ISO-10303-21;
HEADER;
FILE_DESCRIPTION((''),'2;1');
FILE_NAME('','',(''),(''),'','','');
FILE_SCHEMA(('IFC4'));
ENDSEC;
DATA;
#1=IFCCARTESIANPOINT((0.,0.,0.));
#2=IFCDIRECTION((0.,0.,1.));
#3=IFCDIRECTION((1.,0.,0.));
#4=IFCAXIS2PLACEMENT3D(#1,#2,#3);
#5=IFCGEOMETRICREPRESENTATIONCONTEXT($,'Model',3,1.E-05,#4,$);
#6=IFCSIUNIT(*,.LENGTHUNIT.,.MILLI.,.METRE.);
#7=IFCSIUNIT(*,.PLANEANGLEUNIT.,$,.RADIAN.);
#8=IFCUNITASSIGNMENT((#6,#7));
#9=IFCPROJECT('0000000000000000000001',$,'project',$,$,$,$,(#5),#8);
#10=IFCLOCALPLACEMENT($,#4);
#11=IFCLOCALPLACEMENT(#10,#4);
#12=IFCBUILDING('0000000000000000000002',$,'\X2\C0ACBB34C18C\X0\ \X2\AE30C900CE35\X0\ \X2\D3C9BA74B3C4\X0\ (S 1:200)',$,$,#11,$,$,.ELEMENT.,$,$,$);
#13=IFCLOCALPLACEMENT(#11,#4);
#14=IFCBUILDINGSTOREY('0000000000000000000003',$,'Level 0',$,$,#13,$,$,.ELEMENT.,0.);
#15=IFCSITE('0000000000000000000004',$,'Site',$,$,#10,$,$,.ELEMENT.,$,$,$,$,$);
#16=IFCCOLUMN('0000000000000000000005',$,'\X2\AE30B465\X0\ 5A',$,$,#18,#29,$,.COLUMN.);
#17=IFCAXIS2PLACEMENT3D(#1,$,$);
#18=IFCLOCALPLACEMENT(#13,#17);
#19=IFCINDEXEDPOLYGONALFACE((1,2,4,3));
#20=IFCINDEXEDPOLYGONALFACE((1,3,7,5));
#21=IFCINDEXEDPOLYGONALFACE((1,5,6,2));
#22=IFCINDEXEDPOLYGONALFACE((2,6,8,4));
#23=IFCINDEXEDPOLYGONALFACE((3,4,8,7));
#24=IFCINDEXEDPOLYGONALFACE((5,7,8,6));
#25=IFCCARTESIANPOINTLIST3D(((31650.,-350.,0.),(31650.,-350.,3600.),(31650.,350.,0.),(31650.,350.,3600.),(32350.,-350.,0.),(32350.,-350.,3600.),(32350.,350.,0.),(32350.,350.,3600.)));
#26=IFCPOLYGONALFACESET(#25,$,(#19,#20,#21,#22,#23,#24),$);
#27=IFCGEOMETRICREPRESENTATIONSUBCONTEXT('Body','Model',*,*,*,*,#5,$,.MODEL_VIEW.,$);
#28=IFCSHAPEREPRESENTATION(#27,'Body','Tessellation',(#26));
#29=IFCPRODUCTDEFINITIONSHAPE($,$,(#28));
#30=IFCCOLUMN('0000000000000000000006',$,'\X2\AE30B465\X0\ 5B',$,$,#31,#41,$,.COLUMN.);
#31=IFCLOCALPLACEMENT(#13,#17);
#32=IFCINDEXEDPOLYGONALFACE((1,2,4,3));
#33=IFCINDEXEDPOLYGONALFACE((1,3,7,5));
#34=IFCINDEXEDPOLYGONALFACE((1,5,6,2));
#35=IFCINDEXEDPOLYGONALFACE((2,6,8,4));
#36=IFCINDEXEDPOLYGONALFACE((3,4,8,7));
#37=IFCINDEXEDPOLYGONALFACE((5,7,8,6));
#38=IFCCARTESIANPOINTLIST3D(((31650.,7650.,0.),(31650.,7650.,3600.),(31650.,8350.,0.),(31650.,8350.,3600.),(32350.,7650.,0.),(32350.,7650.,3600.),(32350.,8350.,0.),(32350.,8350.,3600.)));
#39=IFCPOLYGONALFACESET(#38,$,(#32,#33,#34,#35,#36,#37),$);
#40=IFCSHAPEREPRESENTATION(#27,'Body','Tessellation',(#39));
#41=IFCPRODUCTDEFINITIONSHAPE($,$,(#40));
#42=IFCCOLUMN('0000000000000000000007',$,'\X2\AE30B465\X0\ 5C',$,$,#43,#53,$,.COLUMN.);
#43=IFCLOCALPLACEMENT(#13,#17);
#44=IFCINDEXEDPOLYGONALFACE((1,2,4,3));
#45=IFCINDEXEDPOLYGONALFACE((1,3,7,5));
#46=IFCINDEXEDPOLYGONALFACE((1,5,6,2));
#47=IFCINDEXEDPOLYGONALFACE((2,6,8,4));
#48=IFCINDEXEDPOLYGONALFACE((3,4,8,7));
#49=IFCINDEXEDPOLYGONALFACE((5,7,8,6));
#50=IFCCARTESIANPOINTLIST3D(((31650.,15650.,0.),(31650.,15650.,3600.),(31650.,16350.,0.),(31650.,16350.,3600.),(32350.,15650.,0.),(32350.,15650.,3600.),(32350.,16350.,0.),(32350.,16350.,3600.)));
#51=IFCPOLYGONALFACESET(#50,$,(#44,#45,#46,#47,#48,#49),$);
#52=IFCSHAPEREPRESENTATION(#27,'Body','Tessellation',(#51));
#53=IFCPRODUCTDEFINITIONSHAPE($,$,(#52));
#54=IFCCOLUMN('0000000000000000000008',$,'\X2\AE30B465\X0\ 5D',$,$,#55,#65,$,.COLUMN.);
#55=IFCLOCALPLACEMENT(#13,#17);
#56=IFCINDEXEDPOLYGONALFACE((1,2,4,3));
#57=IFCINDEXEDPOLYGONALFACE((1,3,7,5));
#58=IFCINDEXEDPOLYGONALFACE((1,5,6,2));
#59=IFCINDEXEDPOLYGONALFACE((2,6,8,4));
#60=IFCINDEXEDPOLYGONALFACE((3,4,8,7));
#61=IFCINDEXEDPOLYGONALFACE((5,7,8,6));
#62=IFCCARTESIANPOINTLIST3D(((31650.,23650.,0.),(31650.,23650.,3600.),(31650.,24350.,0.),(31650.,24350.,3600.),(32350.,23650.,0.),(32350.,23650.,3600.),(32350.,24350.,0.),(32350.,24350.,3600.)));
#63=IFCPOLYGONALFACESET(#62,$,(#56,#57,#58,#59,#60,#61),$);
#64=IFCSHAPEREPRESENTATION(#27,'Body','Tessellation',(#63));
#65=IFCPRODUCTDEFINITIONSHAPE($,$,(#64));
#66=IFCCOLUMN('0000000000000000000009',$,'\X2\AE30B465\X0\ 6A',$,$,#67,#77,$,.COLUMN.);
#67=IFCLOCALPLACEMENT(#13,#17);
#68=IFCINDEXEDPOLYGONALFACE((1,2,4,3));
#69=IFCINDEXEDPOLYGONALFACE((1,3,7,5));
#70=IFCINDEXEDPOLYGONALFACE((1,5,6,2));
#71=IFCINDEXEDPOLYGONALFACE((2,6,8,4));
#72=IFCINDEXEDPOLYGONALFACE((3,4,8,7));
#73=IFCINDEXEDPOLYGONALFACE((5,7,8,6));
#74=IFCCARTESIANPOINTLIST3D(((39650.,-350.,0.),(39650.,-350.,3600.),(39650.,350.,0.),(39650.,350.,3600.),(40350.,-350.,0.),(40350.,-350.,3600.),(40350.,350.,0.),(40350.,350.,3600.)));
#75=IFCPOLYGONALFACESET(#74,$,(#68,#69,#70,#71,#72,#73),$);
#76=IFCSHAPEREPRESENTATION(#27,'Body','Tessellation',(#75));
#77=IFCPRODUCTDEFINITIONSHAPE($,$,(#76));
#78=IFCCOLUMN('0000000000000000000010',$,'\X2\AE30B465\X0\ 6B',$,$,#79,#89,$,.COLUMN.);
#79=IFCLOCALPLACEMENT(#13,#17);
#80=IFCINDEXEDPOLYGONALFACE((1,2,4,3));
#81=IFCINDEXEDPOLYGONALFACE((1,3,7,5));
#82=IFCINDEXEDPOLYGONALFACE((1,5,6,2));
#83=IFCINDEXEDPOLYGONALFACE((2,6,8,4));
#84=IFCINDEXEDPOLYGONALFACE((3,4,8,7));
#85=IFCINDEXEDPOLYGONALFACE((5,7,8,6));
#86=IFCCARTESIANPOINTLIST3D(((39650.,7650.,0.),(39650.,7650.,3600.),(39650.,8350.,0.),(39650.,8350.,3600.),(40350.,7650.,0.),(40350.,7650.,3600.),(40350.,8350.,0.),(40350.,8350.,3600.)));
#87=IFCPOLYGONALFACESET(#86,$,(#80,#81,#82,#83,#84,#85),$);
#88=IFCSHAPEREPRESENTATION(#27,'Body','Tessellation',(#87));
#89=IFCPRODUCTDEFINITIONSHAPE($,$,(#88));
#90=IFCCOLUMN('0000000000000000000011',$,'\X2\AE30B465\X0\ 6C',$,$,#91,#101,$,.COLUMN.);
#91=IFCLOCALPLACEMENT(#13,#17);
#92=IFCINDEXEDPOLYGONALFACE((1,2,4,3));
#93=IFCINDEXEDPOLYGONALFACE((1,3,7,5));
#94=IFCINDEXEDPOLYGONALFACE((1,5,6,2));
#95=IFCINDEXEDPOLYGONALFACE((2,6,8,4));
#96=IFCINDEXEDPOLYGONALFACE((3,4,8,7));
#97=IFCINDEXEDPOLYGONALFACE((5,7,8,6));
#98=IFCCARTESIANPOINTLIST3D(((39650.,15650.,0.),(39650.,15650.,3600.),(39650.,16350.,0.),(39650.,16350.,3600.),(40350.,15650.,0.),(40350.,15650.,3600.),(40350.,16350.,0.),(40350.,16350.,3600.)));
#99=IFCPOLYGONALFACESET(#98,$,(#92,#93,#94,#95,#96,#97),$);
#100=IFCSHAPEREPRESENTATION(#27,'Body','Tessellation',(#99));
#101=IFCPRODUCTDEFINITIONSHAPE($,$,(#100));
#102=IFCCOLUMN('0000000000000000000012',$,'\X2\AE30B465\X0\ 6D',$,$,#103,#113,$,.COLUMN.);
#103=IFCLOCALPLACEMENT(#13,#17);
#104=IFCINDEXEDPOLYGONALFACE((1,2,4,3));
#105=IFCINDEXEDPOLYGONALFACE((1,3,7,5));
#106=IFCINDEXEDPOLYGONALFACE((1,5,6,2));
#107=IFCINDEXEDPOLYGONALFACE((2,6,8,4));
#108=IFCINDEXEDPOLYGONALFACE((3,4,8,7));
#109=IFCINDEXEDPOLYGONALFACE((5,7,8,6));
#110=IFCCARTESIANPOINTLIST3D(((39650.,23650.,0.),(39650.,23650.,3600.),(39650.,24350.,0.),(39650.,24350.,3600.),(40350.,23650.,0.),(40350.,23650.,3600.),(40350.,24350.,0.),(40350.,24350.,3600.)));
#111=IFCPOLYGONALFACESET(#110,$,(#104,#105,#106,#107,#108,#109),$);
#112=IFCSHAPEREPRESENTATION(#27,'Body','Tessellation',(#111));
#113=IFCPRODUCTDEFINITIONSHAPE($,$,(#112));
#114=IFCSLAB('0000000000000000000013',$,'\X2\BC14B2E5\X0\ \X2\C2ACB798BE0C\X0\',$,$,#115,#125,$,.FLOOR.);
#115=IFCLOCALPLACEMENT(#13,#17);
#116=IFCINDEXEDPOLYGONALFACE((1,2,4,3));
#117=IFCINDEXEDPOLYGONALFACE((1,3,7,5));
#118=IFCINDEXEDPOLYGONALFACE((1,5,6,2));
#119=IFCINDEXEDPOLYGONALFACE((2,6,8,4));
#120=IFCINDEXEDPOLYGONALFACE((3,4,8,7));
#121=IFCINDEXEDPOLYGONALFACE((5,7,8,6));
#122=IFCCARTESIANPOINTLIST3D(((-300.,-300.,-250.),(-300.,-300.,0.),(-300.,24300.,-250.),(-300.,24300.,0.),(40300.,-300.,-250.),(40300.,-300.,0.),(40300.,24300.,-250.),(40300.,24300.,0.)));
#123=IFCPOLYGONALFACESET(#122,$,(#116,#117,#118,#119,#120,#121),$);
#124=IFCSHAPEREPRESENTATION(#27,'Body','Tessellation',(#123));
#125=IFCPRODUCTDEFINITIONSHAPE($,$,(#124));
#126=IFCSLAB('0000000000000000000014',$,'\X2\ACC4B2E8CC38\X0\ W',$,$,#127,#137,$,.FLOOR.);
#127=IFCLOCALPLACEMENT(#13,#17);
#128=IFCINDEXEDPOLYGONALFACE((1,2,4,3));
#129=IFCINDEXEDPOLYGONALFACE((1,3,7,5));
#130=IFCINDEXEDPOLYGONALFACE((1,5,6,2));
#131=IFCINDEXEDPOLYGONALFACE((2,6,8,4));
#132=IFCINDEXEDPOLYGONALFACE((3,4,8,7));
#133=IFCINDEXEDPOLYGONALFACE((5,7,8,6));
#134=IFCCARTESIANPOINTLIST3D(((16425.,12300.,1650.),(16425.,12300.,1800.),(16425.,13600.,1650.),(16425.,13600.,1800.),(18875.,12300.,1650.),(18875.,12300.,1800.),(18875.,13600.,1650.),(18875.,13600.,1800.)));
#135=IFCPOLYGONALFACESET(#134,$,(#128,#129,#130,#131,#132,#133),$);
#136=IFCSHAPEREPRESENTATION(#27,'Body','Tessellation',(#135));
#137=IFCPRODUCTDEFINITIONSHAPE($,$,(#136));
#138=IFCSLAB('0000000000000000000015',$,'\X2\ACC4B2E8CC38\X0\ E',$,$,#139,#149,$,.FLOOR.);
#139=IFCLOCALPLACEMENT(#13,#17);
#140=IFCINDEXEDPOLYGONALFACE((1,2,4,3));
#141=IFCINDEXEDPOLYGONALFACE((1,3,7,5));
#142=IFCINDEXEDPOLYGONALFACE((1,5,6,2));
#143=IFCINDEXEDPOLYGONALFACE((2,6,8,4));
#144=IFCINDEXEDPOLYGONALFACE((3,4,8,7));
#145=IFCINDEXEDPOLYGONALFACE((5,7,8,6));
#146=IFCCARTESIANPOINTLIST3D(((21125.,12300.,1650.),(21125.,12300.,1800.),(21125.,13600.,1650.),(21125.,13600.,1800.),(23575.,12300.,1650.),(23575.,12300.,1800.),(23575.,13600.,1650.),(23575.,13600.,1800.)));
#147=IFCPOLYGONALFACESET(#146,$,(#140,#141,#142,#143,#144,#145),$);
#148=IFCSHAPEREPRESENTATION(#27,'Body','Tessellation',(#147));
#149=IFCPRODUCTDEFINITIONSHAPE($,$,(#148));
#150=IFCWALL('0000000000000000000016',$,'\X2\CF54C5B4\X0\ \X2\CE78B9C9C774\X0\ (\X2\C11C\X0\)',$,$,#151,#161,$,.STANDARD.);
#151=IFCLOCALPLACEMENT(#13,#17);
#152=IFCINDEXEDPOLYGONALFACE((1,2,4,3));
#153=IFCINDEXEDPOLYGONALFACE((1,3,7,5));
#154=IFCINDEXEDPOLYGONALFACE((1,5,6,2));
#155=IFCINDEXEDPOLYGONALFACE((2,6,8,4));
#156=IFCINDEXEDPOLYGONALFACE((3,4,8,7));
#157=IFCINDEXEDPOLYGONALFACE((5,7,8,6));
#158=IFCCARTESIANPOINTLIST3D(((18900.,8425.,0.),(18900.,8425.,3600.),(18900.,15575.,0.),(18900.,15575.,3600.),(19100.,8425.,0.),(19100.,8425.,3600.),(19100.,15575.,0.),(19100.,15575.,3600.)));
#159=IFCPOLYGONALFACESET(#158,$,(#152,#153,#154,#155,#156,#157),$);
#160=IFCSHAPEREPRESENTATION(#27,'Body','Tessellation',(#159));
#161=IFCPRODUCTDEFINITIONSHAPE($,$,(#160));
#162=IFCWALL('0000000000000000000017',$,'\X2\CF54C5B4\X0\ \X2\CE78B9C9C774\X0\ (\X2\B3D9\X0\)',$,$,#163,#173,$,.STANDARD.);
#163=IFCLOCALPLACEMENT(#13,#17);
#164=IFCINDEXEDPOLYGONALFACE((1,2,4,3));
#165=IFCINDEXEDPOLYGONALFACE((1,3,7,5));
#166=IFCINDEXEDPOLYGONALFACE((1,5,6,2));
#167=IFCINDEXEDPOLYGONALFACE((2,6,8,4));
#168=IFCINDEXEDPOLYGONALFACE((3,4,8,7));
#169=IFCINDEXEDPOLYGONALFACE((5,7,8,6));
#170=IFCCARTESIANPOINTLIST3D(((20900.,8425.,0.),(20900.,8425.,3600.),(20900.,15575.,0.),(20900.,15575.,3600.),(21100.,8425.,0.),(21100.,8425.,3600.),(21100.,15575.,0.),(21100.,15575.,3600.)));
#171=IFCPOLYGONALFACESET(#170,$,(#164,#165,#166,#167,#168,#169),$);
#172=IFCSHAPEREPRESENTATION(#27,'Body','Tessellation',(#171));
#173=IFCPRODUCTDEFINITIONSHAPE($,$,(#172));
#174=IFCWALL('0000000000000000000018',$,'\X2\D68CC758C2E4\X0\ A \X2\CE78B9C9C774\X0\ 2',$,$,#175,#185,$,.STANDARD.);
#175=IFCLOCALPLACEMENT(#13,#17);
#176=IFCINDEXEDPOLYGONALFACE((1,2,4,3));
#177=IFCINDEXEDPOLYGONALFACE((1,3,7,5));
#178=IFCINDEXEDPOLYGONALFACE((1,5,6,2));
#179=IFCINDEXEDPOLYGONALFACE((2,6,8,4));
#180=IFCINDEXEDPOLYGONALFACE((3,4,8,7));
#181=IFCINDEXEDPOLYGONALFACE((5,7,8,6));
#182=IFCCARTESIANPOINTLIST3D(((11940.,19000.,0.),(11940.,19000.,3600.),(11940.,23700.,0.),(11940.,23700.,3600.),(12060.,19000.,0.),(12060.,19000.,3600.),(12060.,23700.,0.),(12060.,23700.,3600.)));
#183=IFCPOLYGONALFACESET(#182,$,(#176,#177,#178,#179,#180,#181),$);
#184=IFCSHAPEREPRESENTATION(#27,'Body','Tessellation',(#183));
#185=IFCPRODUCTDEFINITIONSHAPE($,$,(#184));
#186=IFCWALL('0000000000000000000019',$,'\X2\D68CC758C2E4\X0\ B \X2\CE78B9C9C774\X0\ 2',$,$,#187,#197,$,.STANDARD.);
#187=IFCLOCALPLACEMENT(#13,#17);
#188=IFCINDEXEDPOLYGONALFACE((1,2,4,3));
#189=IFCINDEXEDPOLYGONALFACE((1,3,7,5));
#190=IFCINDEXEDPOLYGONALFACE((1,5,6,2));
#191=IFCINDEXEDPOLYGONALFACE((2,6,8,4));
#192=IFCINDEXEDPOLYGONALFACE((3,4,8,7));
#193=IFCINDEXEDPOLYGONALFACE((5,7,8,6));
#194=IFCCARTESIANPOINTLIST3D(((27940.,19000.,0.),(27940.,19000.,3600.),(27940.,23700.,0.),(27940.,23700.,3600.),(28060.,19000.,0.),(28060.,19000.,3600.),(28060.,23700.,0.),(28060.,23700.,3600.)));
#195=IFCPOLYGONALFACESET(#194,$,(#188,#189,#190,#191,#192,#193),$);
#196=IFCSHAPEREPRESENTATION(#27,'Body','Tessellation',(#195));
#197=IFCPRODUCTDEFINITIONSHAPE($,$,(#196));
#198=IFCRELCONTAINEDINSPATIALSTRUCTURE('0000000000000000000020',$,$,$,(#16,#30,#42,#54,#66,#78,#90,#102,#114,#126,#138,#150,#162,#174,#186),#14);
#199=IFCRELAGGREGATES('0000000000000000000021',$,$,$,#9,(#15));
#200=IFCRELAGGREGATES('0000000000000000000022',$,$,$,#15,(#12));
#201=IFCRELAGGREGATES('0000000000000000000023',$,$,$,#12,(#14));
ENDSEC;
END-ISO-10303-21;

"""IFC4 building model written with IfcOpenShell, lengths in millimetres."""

from ifc_helpers import new_model, si_unit, frame, frame_2d, origin_with_axes, origin_2d, place, context, subcontext, project, spatial, polyline, rectangle, outline, extrude, element, save


model = new_model("IFC4")

# Units and contexts
model_context = context("Model", 3, precision=1e-05, world=origin_with_axes())
body_context = subcontext(model_context, "Body", "Model", "MODEL_VIEW")
ifc_project = project(units=[si_unit("LENGTHUNIT", "METRE", prefix="MILLI"), si_unit("PLANEANGLEUNIT", "RADIAN")], contexts=[model_context])

# Site, building, storey
site_placement = place(None, origin_with_axes())
site = spatial("IfcSite", under=ifc_project, at=site_placement, Name="Site", CompositionType="ELEMENT")
building_placement = place(site_placement, origin_with_axes())
building = spatial("IfcBuilding", under=site, at=building_placement, Name="사무소 기준층 평면도 (S 1:200)", CompositionType="ELEMENT")
storey_placement = place(building_placement, origin_with_axes())
storey = spatial("IfcBuildingStorey", under=building, at=storey_placement, Name="Level 0", CompositionType="ELEMENT", Elevation=0.0)

# Columns
column_1_placement = place(storey_placement, origin_with_axes())
element("IfcColumn", 1, at=column_1_placement, inside=storey, Name="기둥 5A", PredefinedType="COLUMN", context=body_context, shape_type="SweptSolid", body=[
    extrude(rectangle(XDim=700.0, YDim=700.0, at=origin_2d()), frame((32000.0, 0.0, 0.0), z_axis=(0.0, 0.0, 1.0), x_axis=(1.0, 0.0, 0.0)), (0.0, 0.0, 1.0), 3600.0),
])
column_2_placement = place(storey_placement, origin_with_axes())
element("IfcColumn", 2, at=column_2_placement, inside=storey, Name="기둥 5B", PredefinedType="COLUMN", context=body_context, shape_type="SweptSolid", body=[
    extrude(rectangle(XDim=700.0, YDim=700.0, at=origin_2d()), frame((32000.0, 8000.0, 0.0), z_axis=(0.0, 0.0, 1.0), x_axis=(1.0, 0.0, 0.0)), (0.0, 0.0, 1.0), 3600.0),
])
column_3_placement = place(storey_placement, origin_with_axes())
element("IfcColumn", 3, at=column_3_placement, inside=storey, Name="기둥 5C", PredefinedType="COLUMN", context=body_context, shape_type="SweptSolid", body=[
    extrude(rectangle(XDim=700.0, YDim=700.0, at=origin_2d()), frame((32000.0, 16000.0, 0.0), z_axis=(0.0, 0.0, 1.0), x_axis=(1.0, 0.0, 0.0)), (0.0, 0.0, 1.0), 3600.0),
])
column_4_placement = place(storey_placement, origin_with_axes())
element("IfcColumn", 4, at=column_4_placement, inside=storey, Name="기둥 5D", PredefinedType="COLUMN", context=body_context, shape_type="SweptSolid", body=[
    extrude(rectangle(XDim=700.0, YDim=700.0, at=origin_2d()), frame((32000.0, 24000.0, 0.0), z_axis=(0.0, 0.0, 1.0), x_axis=(1.0, 0.0, 0.0)), (0.0, 0.0, 1.0), 3600.0),
])
column_5_placement = place(storey_placement, origin_with_axes())
element("IfcColumn", 5, at=column_5_placement, inside=storey, Name="기둥 6A", PredefinedType="COLUMN", context=body_context, shape_type="SweptSolid", body=[
    extrude(rectangle(XDim=700.0, YDim=700.0, at=origin_2d()), frame((40000.0, 0.0, 0.0), z_axis=(0.0, 0.0, 1.0), x_axis=(1.0, 0.0, 0.0)), (0.0, 0.0, 1.0), 3600.0),
])
column_6_placement = place(storey_placement, origin_with_axes())
element("IfcColumn", 6, at=column_6_placement, inside=storey, Name="기둥 6B", PredefinedType="COLUMN", context=body_context, shape_type="SweptSolid", body=[
    extrude(rectangle(XDim=700.0, YDim=700.0, at=origin_2d()), frame((40000.0, 8000.0, 0.0), z_axis=(0.0, 0.0, 1.0), x_axis=(1.0, 0.0, 0.0)), (0.0, 0.0, 1.0), 3600.0),
])
column_7_placement = place(storey_placement, origin_with_axes())
element("IfcColumn", 7, at=column_7_placement, inside=storey, Name="기둥 6C", PredefinedType="COLUMN", context=body_context, shape_type="SweptSolid", body=[
    extrude(rectangle(XDim=700.0, YDim=700.0, at=origin_2d()), frame((40000.0, 16000.0, 0.0), z_axis=(0.0, 0.0, 1.0), x_axis=(1.0, 0.0, 0.0)), (0.0, 0.0, 1.0), 3600.0),
])
column_8_placement = place(storey_placement, origin_with_axes())
element("IfcColumn", 8, at=column_8_placement, inside=storey, Name="기둥 6D", PredefinedType="COLUMN", context=body_context, shape_type="SweptSolid", body=[
    extrude(rectangle(XDim=700.0, YDim=700.0, at=origin_2d()), frame((40000.0, 24000.0, 0.0), z_axis=(0.0, 0.0, 1.0), x_axis=(1.0, 0.0, 0.0)), (0.0, 0.0, 1.0), 3600.0),
])

# Slabs
slab_1_placement = place(storey_placement, origin_with_axes())
element("IfcSlab", 9, at=slab_1_placement, inside=storey, Name="바닥 슬래브", PredefinedType="FLOOR", context=body_context, shape_type="SweptSolid", body=[
    extrude(outline(polyline([(-300.0, -300.0), (40300.0, -300.0), (40300.0, 24300.0), (-300.0, 24300.0), (-300.0, -300.0)])), frame((0.0, 0.0, -250.0), z_axis=(0.0, 0.0, 1.0), x_axis=(1.0, 0.0, 0.0)), (0.0, 0.0, 1.0), 250.0),
])
slab_2_placement = place(storey_placement, origin_with_axes())
element("IfcSlab", 10, at=slab_2_placement, inside=storey, Name="계단참 W", PredefinedType="FLOOR", context=body_context, shape_type="SweptSolid", body=[
    extrude(outline(polyline([(16425.0, 12300.0), (18875.0, 12300.0), (18875.0, 13600.0), (16425.0, 13600.0), (16425.0, 12300.0)])), frame((0.0, 0.0, 1650.0), z_axis=(0.0, 0.0, 1.0), x_axis=(1.0, 0.0, 0.0)), (0.0, 0.0, 1.0), 150.0),
])
slab_3_placement = place(storey_placement, origin_with_axes())
element("IfcSlab", 11, at=slab_3_placement, inside=storey, Name="계단참 E", PredefinedType="FLOOR", context=body_context, shape_type="SweptSolid", body=[
    extrude(outline(polyline([(21125.0, 12300.0), (23575.0, 12300.0), (23575.0, 13600.0), (21125.0, 13600.0), (21125.0, 12300.0)])), frame((0.0, 0.0, 1650.0), z_axis=(0.0, 0.0, 1.0), x_axis=(1.0, 0.0, 0.0)), (0.0, 0.0, 1.0), 150.0),
])

# Walls
wall_1_placement = place(storey_placement, origin_with_axes())
element("IfcWall", 12, at=wall_1_placement, inside=storey, Name="코어 칸막이 (서)", PredefinedType="STANDARD", context=body_context, shape_type="SweptSolid", body=[
    extrude(rectangle(XDim=7150.0, YDim=200.0, at=frame_2d((3575.0, 0.0))), frame((19000.0, 8425.0, 0.0), z_axis=(0.0, 0.0, 1.0), x_axis=(0.0, 1.0, 0.0)), (0.0, 0.0, 1.0), 3600.0),
])
wall_2_placement = place(storey_placement, origin_with_axes())
element("IfcWall", 13, at=wall_2_placement, inside=storey, Name="코어 칸막이 (동)", PredefinedType="STANDARD", context=body_context, shape_type="SweptSolid", body=[
    extrude(rectangle(XDim=7150.0, YDim=200.0, at=frame_2d((3575.0, 0.0))), frame((21000.0, 8425.0, 0.0), z_axis=(0.0, 0.0, 1.0), x_axis=(0.0, 1.0, 0.0)), (0.0, 0.0, 1.0), 3600.0),
])
wall_3_placement = place(storey_placement, origin_with_axes())
element("IfcWall", 14, at=wall_3_placement, inside=storey, Name="회의실 A 칸막이 2", PredefinedType="STANDARD", context=body_context, shape_type="SweptSolid", body=[
    extrude(rectangle(XDim=4700.0, YDim=120.0, at=frame_2d((2350.0, 0.0))), frame((12000.0, 19000.0, 0.0), z_axis=(0.0, 0.0, 1.0), x_axis=(0.0, 1.0, 0.0)), (0.0, 0.0, 1.0), 3600.0),
])
wall_4_placement = place(storey_placement, origin_with_axes())
element("IfcWall", 15, at=wall_4_placement, inside=storey, Name="회의실 B 칸막이 2", PredefinedType="STANDARD", context=body_context, shape_type="SweptSolid", body=[
    extrude(rectangle(XDim=4700.0, YDim=120.0, at=frame_2d((2350.0, 0.0))), frame((28000.0, 19000.0, 0.0), z_axis=(0.0, 0.0, 1.0), x_axis=(0.0, 1.0, 0.0)), (0.0, 0.0, 1.0), 3600.0),
])

save(model, "model.ifc")
